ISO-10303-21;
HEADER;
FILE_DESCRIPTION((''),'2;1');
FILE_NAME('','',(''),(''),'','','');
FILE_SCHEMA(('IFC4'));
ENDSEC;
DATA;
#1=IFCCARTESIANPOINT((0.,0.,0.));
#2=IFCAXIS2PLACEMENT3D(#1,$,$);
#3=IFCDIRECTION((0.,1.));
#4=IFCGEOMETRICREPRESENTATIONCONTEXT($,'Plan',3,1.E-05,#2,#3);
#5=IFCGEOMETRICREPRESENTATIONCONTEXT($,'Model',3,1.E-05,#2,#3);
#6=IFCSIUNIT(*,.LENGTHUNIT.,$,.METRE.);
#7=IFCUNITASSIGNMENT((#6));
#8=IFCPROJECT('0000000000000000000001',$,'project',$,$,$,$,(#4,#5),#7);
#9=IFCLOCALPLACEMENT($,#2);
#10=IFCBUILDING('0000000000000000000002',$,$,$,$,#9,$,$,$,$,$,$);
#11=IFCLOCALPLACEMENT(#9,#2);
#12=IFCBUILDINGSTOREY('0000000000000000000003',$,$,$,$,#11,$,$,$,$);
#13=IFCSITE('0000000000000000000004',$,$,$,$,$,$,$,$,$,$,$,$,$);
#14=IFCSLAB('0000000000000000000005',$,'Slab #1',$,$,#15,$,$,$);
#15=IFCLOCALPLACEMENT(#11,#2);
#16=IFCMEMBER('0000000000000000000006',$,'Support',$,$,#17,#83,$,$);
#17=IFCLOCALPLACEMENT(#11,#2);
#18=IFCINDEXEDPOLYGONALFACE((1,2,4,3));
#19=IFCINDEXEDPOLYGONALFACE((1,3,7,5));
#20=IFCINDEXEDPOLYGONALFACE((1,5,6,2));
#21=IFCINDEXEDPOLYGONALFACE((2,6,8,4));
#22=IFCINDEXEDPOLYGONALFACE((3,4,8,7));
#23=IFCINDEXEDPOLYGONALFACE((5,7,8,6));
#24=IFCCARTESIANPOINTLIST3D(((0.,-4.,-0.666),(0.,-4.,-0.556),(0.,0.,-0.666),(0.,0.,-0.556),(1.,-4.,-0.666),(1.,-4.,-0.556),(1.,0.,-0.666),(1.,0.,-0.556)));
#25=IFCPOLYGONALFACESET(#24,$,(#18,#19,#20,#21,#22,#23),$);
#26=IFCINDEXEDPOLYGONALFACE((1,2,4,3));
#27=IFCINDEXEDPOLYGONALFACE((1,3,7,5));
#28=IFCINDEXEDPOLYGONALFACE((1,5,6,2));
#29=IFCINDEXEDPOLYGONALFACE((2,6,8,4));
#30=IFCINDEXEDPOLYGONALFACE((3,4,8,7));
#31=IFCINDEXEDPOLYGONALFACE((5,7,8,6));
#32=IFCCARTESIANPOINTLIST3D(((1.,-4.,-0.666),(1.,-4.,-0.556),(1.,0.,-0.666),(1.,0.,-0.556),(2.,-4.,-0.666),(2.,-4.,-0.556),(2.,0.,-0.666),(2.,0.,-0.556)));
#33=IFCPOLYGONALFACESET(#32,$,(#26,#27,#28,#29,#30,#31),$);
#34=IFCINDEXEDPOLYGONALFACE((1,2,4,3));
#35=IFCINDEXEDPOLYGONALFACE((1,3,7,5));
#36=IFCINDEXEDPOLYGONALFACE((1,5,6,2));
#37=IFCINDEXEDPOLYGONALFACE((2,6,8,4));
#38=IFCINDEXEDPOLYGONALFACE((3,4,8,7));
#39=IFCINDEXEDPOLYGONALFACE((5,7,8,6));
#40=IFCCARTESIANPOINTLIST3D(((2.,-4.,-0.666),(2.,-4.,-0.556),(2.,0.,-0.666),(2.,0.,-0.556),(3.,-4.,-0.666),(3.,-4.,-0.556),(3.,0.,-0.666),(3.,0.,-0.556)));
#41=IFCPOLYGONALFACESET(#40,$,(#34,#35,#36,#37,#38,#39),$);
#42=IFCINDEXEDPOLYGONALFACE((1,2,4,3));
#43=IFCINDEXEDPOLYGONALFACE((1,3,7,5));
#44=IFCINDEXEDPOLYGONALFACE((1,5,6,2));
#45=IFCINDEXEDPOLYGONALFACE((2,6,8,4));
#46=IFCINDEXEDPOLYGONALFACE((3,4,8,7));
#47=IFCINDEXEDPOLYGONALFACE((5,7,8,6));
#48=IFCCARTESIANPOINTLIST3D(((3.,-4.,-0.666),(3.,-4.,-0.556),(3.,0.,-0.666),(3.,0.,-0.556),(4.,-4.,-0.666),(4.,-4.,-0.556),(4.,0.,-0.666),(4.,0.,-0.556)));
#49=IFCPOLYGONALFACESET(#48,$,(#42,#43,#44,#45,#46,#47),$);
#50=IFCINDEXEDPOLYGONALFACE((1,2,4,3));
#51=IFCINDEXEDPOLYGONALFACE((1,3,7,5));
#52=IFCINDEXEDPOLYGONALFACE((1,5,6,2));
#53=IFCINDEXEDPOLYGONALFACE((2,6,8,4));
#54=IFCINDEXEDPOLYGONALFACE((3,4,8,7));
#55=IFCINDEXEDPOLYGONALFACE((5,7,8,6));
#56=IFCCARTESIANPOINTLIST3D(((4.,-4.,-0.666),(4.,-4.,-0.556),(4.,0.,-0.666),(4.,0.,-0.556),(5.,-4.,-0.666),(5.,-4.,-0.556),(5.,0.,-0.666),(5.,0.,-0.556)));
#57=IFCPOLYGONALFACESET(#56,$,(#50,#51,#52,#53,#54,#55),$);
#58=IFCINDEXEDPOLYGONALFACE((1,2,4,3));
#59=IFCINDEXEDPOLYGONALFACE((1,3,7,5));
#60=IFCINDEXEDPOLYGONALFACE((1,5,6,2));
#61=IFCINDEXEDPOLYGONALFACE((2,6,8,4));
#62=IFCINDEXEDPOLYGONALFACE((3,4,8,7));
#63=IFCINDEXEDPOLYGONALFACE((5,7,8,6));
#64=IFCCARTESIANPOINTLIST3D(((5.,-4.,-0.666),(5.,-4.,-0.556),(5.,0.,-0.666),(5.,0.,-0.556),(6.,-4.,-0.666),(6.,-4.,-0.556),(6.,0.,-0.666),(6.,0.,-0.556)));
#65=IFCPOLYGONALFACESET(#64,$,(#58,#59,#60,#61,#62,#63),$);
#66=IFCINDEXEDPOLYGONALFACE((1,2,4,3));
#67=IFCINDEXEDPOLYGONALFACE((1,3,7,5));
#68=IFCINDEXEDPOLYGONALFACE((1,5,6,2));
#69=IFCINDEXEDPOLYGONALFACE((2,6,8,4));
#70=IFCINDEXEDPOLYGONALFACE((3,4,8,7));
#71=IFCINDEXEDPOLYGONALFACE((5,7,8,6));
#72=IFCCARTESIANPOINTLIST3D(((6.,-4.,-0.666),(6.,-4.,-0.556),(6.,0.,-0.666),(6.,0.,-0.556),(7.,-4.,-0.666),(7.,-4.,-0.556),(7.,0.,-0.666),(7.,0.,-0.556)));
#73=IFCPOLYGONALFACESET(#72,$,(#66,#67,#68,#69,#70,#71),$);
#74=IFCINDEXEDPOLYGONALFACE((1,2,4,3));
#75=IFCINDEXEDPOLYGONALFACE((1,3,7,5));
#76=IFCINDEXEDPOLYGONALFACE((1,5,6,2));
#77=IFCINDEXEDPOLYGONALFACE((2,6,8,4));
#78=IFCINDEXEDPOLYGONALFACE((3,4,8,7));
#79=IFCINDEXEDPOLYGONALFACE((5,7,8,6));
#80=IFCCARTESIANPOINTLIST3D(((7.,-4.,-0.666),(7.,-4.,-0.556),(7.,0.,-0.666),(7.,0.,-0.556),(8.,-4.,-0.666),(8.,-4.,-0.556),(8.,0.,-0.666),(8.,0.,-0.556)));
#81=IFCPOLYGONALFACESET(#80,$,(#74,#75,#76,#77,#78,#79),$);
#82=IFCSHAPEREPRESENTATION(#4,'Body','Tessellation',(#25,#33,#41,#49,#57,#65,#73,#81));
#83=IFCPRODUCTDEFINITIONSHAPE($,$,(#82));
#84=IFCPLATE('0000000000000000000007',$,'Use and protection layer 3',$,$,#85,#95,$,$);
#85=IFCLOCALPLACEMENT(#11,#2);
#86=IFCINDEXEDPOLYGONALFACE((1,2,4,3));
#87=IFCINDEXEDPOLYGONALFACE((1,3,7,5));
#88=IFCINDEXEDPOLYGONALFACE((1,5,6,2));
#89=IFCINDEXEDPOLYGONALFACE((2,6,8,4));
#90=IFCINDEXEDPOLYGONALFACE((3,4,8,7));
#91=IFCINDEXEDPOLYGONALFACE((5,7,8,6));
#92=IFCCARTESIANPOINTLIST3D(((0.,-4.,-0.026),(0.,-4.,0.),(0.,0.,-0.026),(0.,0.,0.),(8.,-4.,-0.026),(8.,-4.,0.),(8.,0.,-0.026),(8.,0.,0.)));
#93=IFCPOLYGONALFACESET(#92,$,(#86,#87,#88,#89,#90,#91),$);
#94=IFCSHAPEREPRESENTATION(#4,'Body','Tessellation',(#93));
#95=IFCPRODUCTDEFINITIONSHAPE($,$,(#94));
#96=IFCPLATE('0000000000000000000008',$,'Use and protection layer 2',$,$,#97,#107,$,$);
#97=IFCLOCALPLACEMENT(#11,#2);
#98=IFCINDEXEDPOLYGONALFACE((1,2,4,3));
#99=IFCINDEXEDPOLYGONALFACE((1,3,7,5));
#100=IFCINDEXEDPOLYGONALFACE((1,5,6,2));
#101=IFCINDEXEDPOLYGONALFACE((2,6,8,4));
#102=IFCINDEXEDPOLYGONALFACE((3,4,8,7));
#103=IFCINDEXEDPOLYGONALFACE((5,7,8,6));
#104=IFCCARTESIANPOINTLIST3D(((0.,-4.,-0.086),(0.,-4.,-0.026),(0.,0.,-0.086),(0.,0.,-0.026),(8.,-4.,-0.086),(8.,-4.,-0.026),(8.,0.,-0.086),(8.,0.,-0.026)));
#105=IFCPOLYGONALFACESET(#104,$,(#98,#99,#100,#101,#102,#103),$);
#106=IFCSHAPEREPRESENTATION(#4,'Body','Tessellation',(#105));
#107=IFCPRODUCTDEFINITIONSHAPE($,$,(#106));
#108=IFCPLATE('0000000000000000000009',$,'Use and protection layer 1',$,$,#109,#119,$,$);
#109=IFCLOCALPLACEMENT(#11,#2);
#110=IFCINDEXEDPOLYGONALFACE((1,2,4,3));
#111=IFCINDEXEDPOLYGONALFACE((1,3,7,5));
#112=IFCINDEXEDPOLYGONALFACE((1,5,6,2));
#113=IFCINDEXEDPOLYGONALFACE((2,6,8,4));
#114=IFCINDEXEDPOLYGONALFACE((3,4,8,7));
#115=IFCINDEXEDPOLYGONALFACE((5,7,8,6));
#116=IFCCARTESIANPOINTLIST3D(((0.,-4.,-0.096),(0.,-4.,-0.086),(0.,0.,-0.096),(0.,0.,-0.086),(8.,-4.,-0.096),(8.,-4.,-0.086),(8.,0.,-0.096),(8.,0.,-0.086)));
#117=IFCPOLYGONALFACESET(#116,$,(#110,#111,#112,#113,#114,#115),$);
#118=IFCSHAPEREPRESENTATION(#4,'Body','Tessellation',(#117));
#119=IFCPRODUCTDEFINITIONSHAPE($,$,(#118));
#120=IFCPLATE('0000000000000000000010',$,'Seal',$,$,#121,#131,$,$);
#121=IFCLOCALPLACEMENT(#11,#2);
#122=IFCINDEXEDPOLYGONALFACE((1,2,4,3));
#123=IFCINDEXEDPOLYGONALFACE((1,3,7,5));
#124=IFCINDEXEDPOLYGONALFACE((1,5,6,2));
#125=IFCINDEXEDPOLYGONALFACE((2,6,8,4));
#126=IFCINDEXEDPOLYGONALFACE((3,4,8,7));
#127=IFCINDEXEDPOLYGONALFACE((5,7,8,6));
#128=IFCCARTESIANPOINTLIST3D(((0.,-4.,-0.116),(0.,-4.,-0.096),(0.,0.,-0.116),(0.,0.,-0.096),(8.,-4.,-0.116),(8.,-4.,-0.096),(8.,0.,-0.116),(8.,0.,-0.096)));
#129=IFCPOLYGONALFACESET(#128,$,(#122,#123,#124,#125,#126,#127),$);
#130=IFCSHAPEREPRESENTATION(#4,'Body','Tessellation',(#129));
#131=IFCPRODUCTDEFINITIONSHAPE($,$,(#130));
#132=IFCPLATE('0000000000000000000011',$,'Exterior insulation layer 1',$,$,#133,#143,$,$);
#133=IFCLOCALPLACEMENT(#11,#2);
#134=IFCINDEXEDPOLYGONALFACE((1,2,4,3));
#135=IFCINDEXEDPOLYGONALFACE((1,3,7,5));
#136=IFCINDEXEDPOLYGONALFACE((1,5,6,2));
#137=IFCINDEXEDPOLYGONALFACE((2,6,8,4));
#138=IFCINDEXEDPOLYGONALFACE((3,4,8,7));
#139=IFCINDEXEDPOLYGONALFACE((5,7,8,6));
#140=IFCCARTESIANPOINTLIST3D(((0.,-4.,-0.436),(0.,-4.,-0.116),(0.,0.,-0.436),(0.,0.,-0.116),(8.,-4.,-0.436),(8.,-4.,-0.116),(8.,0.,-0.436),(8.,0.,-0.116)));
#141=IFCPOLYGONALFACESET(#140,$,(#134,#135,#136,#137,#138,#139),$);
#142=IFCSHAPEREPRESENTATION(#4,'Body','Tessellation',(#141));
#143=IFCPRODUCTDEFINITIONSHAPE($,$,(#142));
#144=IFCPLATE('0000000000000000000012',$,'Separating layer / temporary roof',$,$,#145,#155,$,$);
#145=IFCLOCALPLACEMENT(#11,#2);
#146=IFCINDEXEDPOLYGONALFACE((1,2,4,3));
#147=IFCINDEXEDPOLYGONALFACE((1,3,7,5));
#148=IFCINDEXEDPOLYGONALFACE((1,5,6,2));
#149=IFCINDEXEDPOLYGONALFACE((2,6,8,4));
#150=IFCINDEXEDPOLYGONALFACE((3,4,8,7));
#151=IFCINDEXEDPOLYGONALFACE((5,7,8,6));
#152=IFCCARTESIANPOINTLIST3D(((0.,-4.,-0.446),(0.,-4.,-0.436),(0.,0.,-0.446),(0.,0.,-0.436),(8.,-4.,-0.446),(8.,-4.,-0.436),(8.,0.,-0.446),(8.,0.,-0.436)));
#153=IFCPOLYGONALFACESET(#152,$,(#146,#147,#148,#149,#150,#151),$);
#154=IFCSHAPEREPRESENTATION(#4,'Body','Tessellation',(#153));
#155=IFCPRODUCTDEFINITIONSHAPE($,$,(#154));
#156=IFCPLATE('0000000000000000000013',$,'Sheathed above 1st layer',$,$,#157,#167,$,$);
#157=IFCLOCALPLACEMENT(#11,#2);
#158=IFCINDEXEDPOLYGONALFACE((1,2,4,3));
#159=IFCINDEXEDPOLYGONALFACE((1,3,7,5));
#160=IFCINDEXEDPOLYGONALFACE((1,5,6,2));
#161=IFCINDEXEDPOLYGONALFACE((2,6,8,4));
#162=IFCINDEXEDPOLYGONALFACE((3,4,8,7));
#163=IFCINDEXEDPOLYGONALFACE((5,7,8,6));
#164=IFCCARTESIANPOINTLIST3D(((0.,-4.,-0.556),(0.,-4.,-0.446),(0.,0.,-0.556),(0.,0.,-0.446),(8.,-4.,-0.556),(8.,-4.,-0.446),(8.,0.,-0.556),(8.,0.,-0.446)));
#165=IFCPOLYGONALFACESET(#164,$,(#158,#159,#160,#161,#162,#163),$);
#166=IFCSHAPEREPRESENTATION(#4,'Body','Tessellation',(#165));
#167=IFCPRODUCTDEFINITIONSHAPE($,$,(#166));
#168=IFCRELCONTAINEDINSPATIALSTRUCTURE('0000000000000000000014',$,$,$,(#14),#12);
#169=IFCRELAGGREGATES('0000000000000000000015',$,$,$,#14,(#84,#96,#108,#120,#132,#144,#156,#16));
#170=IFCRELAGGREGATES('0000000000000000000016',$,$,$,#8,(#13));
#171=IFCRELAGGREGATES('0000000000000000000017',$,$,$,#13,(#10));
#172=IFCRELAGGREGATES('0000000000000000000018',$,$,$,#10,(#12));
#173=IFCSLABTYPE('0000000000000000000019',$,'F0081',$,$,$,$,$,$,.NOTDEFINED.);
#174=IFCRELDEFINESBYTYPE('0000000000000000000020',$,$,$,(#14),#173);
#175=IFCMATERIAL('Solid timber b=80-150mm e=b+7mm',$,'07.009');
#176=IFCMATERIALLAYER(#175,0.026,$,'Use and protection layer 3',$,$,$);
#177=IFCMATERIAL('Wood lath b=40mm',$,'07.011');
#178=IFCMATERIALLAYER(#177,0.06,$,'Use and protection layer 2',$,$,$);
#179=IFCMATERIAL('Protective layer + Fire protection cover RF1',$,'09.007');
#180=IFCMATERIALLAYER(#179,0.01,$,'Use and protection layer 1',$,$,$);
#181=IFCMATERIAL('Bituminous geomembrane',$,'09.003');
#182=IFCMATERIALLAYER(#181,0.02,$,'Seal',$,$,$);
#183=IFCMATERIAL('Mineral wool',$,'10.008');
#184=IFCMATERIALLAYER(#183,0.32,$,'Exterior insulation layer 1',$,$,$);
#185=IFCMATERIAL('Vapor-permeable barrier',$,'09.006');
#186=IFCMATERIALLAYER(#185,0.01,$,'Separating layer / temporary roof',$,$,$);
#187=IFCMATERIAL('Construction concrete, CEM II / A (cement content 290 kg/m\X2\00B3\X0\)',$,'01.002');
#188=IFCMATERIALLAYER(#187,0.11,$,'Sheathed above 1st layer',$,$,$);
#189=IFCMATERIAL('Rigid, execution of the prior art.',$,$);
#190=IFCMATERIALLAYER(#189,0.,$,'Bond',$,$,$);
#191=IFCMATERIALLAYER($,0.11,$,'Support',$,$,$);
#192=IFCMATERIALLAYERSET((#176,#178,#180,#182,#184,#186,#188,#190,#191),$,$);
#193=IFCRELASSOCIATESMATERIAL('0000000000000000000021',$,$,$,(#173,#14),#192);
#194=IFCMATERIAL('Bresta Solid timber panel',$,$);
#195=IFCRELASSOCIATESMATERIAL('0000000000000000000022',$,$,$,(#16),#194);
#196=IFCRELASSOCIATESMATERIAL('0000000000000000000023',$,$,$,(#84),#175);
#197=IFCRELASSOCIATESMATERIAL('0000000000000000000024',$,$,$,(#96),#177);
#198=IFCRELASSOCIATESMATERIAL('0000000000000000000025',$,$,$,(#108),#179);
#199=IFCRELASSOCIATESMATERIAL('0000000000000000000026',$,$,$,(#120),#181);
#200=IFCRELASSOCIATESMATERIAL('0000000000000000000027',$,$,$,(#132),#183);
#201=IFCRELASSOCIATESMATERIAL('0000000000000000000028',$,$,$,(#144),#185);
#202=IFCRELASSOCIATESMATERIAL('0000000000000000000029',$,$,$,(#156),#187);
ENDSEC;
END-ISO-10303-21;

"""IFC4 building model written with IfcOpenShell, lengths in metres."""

from ifc_helpers import new_model, si_unit, direction, frame, frame_2d, origin, origin_with_axes, place, context, project, spatial, rectangle, extrude, material, layer, layer_set, type_object, element, aggregate, save


model = new_model("IFC4")

# Units and contexts
plan_context = context("Plan", 3, precision=1e-05, world=origin(), true_north=direction((0.0, 1.0)))
model_context = context("Model", 3, precision=1e-05, world=origin(), true_north=direction((0.0, 1.0)))
ifc_project = project(units=[si_unit("LENGTHUNIT", "METRE")], contexts=[plan_context, model_context])

# Site, building, storey
site = spatial("IfcSite", under=ifc_project)
building_placement = place(None, origin())
building = spatial("IfcBuilding", under=site, at=building_placement)
storey_placement = place(building_placement, origin())
storey = spatial("IfcBuildingStorey", under=building, at=storey_placement)

# Slab, member, plates
ifc_material_1 = material(Name="Solid timber b=80-150mm e=b+7mm", Category="07.009")
ifc_layer_1 = layer(ifc_material_1, 0.026, Name="Use and protection layer 3")
ifc_material_2 = material(Name="Wood lath b=40mm", Category="07.011")
ifc_layer_2 = layer(ifc_material_2, 0.06, Name="Use and protection layer 2")
ifc_material_3 = material(Name="Protective layer + Fire protection cover RF1", Category="09.007")
ifc_layer_3 = layer(ifc_material_3, 0.01, Name="Use and protection layer 1")
ifc_material_4 = material(Name="Bituminous geomembrane", Category="09.003")
ifc_layer_4 = layer(ifc_material_4, 0.02, Name="Seal")
ifc_material_5 = material(Name="Mineral wool", Category="10.008")
ifc_layer_5 = layer(ifc_material_5, 0.32, Name="Exterior insulation layer 1")
ifc_material_6 = material(Name="Vapor-permeable barrier", Category="09.006")
ifc_layer_6 = layer(ifc_material_6, 0.01, Name="Separating layer / temporary roof")
ifc_material_7 = material(Name="Construction concrete, CEM II / A (cement content 290 kg/m³)", Category="01.002")
ifc_layer_7 = layer(ifc_material_7, 0.11, Name="Sheathed above 1st layer")
ifc_material_8 = material(Name="Rigid, execution of the prior art.")
ifc_layer_8 = layer(ifc_material_8, 0.0, Name="Bond")
ifc_layer_9 = layer(None, 0.11, Name="Support")
ifc_layer_set = layer_set([ifc_layer_1, ifc_layer_2, ifc_layer_3, ifc_layer_4, ifc_layer_5, ifc_layer_6, ifc_layer_7, ifc_layer_8, ifc_layer_9])
slab_type = type_object("IfcSlabType", Name="F0081", PredefinedType="NOTDEFINED", material=ifc_layer_set)
slab_placement = place(None, frame((0.0, 0.0, 0.0), z_axis=(0.0, 0.0, -1.0), x_axis=(1.0, 0.0, 0.0)))
slab = element("IfcSlab", 1, at=slab_placement, inside=storey, type_object=slab_type, material=ifc_layer_set, Name="Slab #1")
ifc_material_9 = material(Name="Bresta Solid timber panel")
member_placement = place(slab_placement, origin())
member = element("IfcMember", 2, at=member_placement, material=ifc_material_9, Name="Support", context=plan_context, shape_type="SweptSolid", body=[
    extrude(rectangle(XDim=1.0, YDim=0.11, at=frame_2d((0.5, 0.055), x_axis=(1.0, 0.0))), frame((0.0, 4.0, 0.556), z_axis=(0.0, -1.0, 0.0), x_axis=(1.0, 0.0, 0.0)), (0.0, 0.0, 1.0), 4.0),
    extrude(rectangle(XDim=1.0, YDim=0.11, at=frame_2d((0.5, 0.055), x_axis=(1.0, 0.0))), frame((1.0, 4.0, 0.556), z_axis=(0.0, -1.0, 0.0), x_axis=(1.0, 0.0, 0.0)), (0.0, 0.0, 1.0), 4.0),
    extrude(rectangle(XDim=1.0, YDim=0.11, at=frame_2d((0.5, 0.055), x_axis=(1.0, 0.0))), frame((2.0, 4.0, 0.556), z_axis=(0.0, -1.0, 0.0), x_axis=(1.0, 0.0, 0.0)), (0.0, 0.0, 1.0), 4.0),
    extrude(rectangle(XDim=1.0, YDim=0.11, at=frame_2d((0.5, 0.055), x_axis=(1.0, 0.0))), frame((3.0, 4.0, 0.556), z_axis=(0.0, -1.0, 0.0), x_axis=(1.0, 0.0, 0.0)), (0.0, 0.0, 1.0), 4.0),
    extrude(rectangle(XDim=1.0, YDim=0.11, at=frame_2d((0.5, 0.055), x_axis=(1.0, 0.0))), frame((4.0, 4.0, 0.556), z_axis=(0.0, -1.0, 0.0), x_axis=(1.0, 0.0, 0.0)), (0.0, 0.0, 1.0), 4.0),
    extrude(rectangle(XDim=1.0, YDim=0.11, at=frame_2d((0.5, 0.055), x_axis=(1.0, 0.0))), frame((5.0, 4.0, 0.556), z_axis=(0.0, -1.0, 0.0), x_axis=(1.0, 0.0, 0.0)), (0.0, 0.0, 1.0), 4.0),
    extrude(rectangle(XDim=1.0, YDim=0.11, at=frame_2d((0.5, 0.055), x_axis=(1.0, 0.0))), frame((6.0, 4.0, 0.556), z_axis=(0.0, -1.0, 0.0), x_axis=(1.0, 0.0, 0.0)), (0.0, 0.0, 1.0), 4.0),
    extrude(rectangle(XDim=1.0, YDim=0.11, at=frame_2d((0.5, 0.055), x_axis=(1.0, 0.0))), frame((7.0, 4.0, 0.556), z_axis=(0.0, -1.0, 0.0), x_axis=(1.0, 0.0, 0.0)), (0.0, 0.0, 1.0), 4.0),
])
plate_1_placement = place(slab_placement, origin())
plate_1 = element("IfcPlate", 3, at=plate_1_placement, material=ifc_material_1, Name="Use and protection layer 3", context=plan_context, shape_type="SweptSolid", body=[
    extrude(rectangle(XDim=8.0, YDim=4.0, at=frame_2d((4.0, 2.0), x_axis=(1.0, 0.0))), origin_with_axes(), (0.0, 0.0, 1.0), 0.026),
])
plate_2_placement = place(slab_placement, origin())
plate_2 = element("IfcPlate", 4, at=plate_2_placement, material=ifc_material_2, Name="Use and protection layer 2", context=plan_context, shape_type="SweptSolid", body=[
    extrude(rectangle(XDim=8.0, YDim=4.0, at=frame_2d((4.0, 2.0), x_axis=(1.0, 0.0))), frame((0.0, 0.0, 0.026), z_axis=(0.0, 0.0, 1.0), x_axis=(1.0, 0.0, 0.0)), (0.0, 0.0, 1.0), 0.06),
])
plate_3_placement = place(slab_placement, origin())
plate_3 = element("IfcPlate", 5, at=plate_3_placement, material=ifc_material_3, Name="Use and protection layer 1", context=plan_context, shape_type="SweptSolid", body=[
    extrude(rectangle(XDim=8.0, YDim=4.0, at=frame_2d((4.0, 2.0), x_axis=(1.0, 0.0))), frame((0.0, 0.0, 0.086), z_axis=(0.0, 0.0, 1.0), x_axis=(1.0, 0.0, 0.0)), (0.0, 0.0, 1.0), 0.01),
])
plate_4_placement = place(slab_placement, origin())
plate_4 = element("IfcPlate", 6, at=plate_4_placement, material=ifc_material_4, Name="Seal", context=plan_context, shape_type="SweptSolid", body=[
    extrude(rectangle(XDim=8.0, YDim=4.0, at=frame_2d((4.0, 2.0), x_axis=(1.0, 0.0))), frame((0.0, 0.0, 0.096), z_axis=(0.0, 0.0, 1.0), x_axis=(1.0, 0.0, 0.0)), (0.0, 0.0, 1.0), 0.02),
])
plate_5_placement = place(slab_placement, origin())
plate_5 = element("IfcPlate", 7, at=plate_5_placement, material=ifc_material_5, Name="Exterior insulation layer 1", context=plan_context, shape_type="SweptSolid", body=[
    extrude(rectangle(XDim=8.0, YDim=4.0, at=frame_2d((4.0, 2.0), x_axis=(1.0, 0.0))), frame((0.0, 0.0, 0.116), z_axis=(0.0, 0.0, 1.0), x_axis=(1.0, 0.0, 0.0)), (0.0, 0.0, 1.0), 0.32),
])
plate_6_placement = place(slab_placement, origin())
plate_6 = element("IfcPlate", 8, at=plate_6_placement, material=ifc_material_6, Name="Separating layer / temporary roof", context=plan_context, shape_type="SweptSolid", body=[
    extrude(rectangle(XDim=8.0, YDim=4.0, at=frame_2d((4.0, 2.0), x_axis=(1.0, 0.0))), frame((0.0, 0.0, 0.436), z_axis=(0.0, 0.0, 1.0), x_axis=(1.0, 0.0, 0.0)), (0.0, 0.0, 1.0), 0.01),
])
plate_7_placement = place(slab_placement, origin())
plate_7 = element("IfcPlate", 9, at=plate_7_placement, material=ifc_material_7, Name="Sheathed above 1st layer", context=plan_context, shape_type="SweptSolid", body=[
    extrude(rectangle(XDim=8.0, YDim=4.0, at=frame_2d((4.0, 2.0), x_axis=(1.0, 0.0))), frame((0.0, 0.0, 0.446), z_axis=(0.0, 0.0, 1.0), x_axis=(1.0, 0.0, 0.0)), (0.0, 0.0, 1.0), 0.11),
])
aggregate(slab, [plate_1, plate_2, plate_3, plate_4, plate_5, plate_6, plate_7, member])

save(model, "model.ifc")
